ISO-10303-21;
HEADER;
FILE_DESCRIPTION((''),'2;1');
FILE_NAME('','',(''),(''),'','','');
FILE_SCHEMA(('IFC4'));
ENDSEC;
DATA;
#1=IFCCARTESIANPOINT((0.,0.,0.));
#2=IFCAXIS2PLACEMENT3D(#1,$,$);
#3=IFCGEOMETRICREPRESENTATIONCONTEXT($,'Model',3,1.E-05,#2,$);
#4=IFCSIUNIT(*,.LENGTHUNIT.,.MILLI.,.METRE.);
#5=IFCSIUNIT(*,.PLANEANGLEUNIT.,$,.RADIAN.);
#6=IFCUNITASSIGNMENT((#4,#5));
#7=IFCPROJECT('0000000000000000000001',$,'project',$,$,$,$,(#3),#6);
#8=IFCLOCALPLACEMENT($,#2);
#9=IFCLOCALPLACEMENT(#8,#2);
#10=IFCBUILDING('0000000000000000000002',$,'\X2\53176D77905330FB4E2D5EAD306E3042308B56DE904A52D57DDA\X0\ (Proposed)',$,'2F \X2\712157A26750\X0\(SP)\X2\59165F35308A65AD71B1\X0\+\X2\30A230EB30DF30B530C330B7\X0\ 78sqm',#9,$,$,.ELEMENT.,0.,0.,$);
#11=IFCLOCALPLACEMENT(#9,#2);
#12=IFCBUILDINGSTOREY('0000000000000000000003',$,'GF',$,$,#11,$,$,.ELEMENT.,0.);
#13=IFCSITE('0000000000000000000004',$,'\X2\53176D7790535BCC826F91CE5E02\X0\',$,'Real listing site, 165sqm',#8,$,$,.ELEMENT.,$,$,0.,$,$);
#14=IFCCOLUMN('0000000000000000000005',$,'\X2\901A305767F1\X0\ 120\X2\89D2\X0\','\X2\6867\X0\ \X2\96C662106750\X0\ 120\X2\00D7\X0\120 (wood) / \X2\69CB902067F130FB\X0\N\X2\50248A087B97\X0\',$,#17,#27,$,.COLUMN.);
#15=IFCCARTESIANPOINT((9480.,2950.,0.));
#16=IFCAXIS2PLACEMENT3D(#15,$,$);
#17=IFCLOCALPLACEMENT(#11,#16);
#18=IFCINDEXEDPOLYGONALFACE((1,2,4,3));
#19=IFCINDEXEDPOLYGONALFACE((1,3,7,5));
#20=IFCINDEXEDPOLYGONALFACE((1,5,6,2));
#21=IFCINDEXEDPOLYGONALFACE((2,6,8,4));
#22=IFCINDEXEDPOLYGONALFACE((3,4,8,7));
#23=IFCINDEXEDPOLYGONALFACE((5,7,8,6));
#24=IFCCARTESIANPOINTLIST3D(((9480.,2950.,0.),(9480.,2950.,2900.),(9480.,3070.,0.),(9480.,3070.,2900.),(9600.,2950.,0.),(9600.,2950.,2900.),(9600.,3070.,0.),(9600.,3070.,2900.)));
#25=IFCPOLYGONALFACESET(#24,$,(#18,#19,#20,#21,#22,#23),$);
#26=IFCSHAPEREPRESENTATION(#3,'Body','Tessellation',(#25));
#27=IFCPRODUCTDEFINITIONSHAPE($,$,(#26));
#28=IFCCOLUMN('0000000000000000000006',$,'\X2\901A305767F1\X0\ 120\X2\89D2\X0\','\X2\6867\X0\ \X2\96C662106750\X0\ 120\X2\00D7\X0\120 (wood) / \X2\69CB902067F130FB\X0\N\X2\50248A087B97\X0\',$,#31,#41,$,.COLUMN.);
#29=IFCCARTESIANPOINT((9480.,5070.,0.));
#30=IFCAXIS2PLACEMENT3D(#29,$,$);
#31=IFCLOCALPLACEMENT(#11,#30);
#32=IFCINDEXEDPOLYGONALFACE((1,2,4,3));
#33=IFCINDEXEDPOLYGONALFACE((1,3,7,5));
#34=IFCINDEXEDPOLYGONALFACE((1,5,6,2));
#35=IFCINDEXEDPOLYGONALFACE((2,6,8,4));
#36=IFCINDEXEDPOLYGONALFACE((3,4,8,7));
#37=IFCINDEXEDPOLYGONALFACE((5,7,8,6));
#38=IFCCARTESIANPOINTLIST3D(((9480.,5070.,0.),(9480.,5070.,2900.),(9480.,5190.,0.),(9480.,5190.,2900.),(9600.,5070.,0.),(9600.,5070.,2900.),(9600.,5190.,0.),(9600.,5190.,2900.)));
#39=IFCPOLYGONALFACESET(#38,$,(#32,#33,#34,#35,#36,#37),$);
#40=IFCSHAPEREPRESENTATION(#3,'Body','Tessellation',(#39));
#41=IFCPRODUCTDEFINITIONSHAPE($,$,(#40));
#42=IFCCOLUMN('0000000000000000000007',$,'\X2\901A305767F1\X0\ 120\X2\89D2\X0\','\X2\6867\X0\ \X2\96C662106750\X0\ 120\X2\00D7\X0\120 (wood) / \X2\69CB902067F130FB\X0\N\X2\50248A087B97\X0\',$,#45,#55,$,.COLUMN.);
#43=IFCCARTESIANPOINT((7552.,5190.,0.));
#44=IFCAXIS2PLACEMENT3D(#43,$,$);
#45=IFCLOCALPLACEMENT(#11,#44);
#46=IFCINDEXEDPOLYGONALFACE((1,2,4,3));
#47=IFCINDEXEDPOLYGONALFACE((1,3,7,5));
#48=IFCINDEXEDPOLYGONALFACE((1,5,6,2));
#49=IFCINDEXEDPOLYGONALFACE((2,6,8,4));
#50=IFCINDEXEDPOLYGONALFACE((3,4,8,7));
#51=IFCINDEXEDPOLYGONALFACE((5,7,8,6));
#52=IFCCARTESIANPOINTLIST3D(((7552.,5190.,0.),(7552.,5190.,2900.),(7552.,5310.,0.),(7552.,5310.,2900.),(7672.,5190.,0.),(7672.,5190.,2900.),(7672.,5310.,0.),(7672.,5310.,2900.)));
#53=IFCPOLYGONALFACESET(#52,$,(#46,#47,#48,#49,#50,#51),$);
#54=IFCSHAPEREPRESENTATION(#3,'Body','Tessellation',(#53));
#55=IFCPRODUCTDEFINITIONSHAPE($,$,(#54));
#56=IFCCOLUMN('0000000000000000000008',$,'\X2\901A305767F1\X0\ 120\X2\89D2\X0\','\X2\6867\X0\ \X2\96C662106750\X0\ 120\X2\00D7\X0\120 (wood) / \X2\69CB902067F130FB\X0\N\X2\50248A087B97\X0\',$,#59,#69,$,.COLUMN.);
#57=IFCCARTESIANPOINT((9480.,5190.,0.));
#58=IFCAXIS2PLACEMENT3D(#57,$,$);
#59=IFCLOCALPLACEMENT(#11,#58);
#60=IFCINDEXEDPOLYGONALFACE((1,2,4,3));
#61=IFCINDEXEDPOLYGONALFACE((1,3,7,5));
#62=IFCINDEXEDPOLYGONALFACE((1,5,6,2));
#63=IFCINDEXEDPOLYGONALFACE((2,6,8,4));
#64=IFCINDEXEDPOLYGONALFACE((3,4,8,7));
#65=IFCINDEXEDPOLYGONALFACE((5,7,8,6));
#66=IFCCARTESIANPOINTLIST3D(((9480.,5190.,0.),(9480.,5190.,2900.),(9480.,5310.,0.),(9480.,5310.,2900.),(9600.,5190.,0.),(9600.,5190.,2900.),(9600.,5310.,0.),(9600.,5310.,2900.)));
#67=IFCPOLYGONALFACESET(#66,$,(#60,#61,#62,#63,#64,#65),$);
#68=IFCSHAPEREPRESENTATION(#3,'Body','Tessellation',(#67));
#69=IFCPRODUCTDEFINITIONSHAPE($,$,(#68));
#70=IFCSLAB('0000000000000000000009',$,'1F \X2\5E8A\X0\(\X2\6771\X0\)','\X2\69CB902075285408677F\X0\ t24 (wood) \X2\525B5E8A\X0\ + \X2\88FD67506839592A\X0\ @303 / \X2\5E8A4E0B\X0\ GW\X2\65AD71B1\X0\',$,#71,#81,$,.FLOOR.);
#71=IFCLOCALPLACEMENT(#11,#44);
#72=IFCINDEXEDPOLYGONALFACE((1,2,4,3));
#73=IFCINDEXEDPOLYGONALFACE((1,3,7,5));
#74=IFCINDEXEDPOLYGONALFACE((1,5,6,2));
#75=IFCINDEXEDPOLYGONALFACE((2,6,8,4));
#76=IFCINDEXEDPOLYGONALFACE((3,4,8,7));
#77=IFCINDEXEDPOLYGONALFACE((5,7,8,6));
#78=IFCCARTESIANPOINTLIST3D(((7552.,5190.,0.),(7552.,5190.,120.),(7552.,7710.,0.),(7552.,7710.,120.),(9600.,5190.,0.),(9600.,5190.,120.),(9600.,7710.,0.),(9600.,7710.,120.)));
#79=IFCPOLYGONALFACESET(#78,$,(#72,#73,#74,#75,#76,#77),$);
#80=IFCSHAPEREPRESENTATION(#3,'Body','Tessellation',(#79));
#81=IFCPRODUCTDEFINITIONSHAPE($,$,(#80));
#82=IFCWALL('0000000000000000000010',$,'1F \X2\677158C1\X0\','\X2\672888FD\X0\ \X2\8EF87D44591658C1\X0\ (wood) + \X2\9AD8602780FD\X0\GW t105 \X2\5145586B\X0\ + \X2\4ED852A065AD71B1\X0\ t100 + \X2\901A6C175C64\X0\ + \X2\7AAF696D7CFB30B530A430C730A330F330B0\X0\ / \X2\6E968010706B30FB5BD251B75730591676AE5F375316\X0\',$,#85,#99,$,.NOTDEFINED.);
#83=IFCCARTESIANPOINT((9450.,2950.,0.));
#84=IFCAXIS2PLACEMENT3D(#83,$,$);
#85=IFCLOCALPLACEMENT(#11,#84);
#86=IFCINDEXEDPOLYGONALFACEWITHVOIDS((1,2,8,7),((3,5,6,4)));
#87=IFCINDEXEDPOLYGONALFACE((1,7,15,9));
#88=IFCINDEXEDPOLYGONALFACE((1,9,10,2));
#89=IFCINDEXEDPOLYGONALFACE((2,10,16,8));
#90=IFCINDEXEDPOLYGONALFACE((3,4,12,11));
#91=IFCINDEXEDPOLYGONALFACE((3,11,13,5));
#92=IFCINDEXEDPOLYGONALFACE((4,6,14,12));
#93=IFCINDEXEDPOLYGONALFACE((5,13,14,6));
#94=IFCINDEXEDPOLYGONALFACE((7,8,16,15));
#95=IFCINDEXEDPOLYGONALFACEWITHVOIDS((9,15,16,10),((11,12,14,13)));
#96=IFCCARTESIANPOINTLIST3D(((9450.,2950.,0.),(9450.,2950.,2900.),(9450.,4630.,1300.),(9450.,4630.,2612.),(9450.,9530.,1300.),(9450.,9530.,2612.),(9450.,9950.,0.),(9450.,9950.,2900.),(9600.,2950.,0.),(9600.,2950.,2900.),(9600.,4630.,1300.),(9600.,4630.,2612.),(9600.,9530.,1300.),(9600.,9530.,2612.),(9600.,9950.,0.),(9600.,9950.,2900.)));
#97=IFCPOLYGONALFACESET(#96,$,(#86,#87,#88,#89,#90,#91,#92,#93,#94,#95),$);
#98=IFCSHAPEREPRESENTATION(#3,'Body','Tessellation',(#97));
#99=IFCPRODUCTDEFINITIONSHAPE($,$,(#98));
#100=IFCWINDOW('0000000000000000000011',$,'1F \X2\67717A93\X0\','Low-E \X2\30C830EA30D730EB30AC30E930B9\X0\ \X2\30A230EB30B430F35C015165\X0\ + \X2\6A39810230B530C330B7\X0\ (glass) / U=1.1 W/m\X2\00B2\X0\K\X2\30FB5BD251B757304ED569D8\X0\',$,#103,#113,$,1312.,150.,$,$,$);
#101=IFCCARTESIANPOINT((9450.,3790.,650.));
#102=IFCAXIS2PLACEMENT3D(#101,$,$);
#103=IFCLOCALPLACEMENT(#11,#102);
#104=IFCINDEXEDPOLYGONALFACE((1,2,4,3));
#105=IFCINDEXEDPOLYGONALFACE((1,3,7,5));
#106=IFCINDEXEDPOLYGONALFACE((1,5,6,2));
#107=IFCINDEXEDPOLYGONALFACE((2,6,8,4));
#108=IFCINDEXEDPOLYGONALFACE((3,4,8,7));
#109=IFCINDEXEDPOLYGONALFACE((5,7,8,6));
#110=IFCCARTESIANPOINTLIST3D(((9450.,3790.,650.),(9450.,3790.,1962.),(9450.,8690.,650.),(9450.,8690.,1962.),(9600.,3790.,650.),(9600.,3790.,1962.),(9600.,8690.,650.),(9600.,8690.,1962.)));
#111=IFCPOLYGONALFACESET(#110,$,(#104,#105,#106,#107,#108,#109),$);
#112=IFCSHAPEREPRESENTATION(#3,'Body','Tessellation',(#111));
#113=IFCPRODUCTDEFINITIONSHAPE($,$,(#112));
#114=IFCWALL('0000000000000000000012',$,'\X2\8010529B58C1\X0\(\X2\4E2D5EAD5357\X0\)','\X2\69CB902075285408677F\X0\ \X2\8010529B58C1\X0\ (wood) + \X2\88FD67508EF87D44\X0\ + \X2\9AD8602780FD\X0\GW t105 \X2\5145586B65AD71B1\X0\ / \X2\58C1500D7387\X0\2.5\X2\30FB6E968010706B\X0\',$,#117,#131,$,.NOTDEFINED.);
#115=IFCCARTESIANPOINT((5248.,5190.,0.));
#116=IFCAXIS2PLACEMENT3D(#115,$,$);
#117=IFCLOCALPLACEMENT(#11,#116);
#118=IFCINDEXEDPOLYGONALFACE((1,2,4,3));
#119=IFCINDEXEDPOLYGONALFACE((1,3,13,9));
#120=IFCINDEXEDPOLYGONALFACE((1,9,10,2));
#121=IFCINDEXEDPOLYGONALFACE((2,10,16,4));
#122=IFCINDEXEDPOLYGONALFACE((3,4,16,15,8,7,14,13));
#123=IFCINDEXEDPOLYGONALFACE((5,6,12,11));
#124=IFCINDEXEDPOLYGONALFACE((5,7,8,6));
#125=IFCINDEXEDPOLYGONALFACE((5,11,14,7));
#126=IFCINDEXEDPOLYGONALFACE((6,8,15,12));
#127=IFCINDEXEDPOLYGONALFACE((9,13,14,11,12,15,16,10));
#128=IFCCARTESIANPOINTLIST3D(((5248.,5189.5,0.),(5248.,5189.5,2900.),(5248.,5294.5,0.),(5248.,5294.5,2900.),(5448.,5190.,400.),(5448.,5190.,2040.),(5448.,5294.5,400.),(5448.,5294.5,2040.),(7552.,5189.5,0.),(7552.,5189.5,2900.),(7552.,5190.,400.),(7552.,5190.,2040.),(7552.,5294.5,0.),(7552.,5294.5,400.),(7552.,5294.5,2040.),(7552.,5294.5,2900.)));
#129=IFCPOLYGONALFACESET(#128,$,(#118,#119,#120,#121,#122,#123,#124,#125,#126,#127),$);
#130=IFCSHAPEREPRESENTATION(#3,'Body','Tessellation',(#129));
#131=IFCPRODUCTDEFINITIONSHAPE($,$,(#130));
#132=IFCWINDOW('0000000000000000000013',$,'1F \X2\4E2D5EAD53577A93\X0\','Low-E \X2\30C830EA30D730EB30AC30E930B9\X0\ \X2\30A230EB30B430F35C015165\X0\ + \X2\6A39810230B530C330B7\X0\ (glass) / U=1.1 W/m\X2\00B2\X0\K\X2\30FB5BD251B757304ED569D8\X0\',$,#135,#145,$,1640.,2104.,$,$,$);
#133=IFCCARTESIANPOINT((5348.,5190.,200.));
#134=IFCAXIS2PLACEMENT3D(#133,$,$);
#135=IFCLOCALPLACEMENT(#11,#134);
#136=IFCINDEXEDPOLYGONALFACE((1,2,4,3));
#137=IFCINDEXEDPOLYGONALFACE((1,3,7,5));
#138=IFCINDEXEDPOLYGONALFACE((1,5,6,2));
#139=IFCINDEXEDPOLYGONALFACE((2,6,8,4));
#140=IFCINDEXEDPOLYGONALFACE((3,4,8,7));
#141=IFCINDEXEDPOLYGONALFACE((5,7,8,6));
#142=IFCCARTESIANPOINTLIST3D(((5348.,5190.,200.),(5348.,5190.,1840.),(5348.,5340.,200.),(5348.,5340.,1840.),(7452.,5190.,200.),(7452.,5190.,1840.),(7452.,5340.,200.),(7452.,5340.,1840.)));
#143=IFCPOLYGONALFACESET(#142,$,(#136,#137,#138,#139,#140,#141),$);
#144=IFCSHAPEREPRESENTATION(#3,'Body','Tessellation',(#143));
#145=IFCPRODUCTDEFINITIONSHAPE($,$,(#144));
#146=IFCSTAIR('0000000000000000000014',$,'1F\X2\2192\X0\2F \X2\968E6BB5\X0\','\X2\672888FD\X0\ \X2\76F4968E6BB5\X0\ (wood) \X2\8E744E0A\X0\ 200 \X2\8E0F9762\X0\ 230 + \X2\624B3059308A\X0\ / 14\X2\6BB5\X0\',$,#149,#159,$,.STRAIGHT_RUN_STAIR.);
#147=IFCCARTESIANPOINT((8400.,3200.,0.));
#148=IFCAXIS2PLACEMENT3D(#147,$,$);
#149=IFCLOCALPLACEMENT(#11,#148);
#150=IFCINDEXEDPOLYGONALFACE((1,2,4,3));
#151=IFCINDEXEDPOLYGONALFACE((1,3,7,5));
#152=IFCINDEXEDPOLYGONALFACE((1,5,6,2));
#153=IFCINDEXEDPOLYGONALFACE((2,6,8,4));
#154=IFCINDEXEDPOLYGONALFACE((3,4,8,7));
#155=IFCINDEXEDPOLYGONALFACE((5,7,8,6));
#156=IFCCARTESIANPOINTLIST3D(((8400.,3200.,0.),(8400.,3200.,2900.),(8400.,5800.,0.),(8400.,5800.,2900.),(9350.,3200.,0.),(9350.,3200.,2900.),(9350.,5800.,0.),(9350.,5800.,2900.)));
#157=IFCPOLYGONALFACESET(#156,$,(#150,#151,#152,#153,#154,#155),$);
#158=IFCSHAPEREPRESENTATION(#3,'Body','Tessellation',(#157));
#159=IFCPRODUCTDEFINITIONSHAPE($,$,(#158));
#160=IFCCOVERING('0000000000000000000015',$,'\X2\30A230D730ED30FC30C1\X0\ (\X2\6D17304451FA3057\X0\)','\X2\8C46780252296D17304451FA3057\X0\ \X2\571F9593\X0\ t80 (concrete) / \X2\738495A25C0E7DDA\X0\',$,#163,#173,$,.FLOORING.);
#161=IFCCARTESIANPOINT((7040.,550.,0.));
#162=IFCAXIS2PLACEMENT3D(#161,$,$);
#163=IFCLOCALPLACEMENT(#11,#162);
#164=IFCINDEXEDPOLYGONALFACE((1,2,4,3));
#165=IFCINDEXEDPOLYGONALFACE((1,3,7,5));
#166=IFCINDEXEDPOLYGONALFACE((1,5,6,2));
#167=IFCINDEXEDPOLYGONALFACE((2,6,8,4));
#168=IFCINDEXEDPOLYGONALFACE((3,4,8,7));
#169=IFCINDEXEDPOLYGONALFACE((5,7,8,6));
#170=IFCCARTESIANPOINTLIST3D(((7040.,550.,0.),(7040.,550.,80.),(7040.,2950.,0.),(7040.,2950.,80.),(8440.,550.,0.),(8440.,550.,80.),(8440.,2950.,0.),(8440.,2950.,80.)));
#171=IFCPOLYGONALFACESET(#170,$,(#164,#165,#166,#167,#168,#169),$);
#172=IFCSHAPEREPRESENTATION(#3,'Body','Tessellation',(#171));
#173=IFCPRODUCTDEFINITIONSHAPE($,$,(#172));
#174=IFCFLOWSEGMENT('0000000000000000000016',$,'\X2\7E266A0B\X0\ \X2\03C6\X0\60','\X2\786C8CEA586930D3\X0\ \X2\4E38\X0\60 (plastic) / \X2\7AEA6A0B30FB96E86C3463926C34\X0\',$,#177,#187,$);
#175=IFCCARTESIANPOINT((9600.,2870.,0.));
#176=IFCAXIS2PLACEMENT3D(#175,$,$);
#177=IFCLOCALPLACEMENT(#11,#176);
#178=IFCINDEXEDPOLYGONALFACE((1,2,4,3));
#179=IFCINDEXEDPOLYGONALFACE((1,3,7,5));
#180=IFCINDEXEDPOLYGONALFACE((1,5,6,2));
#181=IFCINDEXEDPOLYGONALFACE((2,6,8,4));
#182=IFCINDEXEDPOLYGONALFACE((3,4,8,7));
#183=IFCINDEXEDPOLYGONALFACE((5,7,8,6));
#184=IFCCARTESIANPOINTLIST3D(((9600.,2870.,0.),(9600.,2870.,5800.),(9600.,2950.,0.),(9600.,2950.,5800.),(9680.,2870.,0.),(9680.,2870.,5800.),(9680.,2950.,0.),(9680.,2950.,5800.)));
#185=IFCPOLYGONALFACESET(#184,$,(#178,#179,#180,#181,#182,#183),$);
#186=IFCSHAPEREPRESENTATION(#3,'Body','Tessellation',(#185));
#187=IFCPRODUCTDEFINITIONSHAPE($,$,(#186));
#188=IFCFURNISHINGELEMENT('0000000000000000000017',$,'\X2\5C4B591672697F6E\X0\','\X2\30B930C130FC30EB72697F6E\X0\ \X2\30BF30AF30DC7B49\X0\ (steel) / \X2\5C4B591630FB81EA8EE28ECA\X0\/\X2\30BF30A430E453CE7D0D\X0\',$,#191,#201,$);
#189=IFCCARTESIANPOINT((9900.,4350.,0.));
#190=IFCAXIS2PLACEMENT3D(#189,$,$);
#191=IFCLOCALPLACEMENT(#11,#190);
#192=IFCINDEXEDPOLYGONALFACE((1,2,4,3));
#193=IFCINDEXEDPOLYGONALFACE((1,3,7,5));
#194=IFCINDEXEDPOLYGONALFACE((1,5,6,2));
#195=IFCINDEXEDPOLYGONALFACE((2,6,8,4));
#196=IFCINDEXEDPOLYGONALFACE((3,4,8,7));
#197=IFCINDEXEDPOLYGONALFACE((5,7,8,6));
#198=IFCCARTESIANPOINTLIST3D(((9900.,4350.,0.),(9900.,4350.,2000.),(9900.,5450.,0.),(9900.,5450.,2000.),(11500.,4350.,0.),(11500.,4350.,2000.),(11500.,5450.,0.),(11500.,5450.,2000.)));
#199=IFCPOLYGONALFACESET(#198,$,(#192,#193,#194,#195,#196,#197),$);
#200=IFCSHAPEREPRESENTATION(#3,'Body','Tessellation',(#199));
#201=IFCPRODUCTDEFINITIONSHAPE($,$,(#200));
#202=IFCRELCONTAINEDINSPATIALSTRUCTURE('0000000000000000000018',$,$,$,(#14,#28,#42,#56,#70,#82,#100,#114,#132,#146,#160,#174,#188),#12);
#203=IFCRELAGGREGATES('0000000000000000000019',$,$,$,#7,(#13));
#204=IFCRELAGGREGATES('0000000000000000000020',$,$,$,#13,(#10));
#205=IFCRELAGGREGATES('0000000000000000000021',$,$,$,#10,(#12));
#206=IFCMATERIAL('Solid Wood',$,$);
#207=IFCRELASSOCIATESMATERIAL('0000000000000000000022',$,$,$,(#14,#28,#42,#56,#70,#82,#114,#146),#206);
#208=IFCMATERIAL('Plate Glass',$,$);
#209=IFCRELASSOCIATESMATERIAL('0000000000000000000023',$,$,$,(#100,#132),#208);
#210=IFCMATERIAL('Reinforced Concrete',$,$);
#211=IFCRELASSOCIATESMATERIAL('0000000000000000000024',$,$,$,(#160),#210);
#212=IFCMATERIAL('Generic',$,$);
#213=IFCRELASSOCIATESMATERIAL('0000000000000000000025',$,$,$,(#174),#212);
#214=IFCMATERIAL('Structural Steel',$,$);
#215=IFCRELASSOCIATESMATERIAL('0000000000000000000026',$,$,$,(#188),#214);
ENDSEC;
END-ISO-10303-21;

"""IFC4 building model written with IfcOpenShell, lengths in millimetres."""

from ifc_helpers import new_model, si_unit, frame, frame_2d, origin, place, context, project, spatial, rectangle, extrude, material, element, fill, save


model = new_model("IFC4")

# Units and contexts
model_context = context("Model", 3, precision=1e-05, world=origin())
ifc_project = project(units=[si_unit("LENGTHUNIT", "METRE", prefix="MILLI"), si_unit("PLANEANGLEUNIT", "RADIAN")], contexts=[model_context])

# Site, building, storey
site_placement = place(None, origin())
site = spatial("IfcSite", under=ifc_project, at=site_placement, Name="北海道富良野市", ObjectType="Real listing site, 165sqm", CompositionType="ELEMENT", RefElevation=0.0)
building_placement = place(site_placement, origin())
building = spatial("IfcBuilding", under=site, at=building_placement, Name="北海道・中庭のある回遊動線 (Proposed)", ObjectType="2F 無垢材(SP)外張り断熱+アルミサッシ 78sqm", CompositionType="ELEMENT", ElevationOfRefHeight=0.0, ElevationOfTerrain=0.0)
storey_placement = place(building_placement, origin())
storey = spatial("IfcBuildingStorey", under=building, at=storey_placement, Name="GF", CompositionType="ELEMENT", Elevation=0.0)

# Columns
ifc_material_1 = material(Name="Solid Wood")
column_1_placement = place(storey_placement, frame((9480.0, 2950.0, 0.0)))
element("IfcColumn", 1, at=column_1_placement, inside=storey, material=ifc_material_1, Name="通し柱 120角", Description="桧 集成材 120×120 (wood) / 構造柱・N値計算", PredefinedType="COLUMN", context=model_context, shape_type="SweptSolid", body=[
    extrude(rectangle(XDim=120.0, YDim=120.0, at=frame_2d((60.0, 60.0))), frame((9480.0, 2950.0, 0.0)), (0.0, 0.0, 1.0), 2900.0),
])
column_2_placement = place(storey_placement, frame((9480.0, 5070.0, 0.0)))
element("IfcColumn", 2, at=column_2_placement, inside=storey, material=ifc_material_1, Name="通し柱 120角", Description="桧 集成材 120×120 (wood) / 構造柱・N値計算", PredefinedType="COLUMN", context=model_context, shape_type="SweptSolid", body=[
    extrude(rectangle(XDim=120.0, YDim=120.0, at=frame_2d((60.0, 60.0))), frame((9480.0, 5070.0, 0.0)), (0.0, 0.0, 1.0), 2900.0),
])
column_3_placement = place(storey_placement, frame((7552.0, 5190.0, 0.0)))
element("IfcColumn", 3, at=column_3_placement, inside=storey, material=ifc_material_1, Name="通し柱 120角", Description="桧 集成材 120×120 (wood) / 構造柱・N値計算", PredefinedType="COLUMN", context=model_context, shape_type="SweptSolid", body=[
    extrude(rectangle(XDim=120.0, YDim=120.0, at=frame_2d((60.0, 60.0))), frame((7552.0, 5190.0, 0.0)), (0.0, 0.0, 1.0), 2900.0),
])
column_4_placement = place(storey_placement, frame((9480.0, 5190.0, 0.0)))
element("IfcColumn", 4, at=column_4_placement, inside=storey, material=ifc_material_1, Name="通し柱 120角", Description="桧 集成材 120×120 (wood) / 構造柱・N値計算", PredefinedType="COLUMN", context=model_context, shape_type="SweptSolid", body=[
    extrude(rectangle(XDim=120.0, YDim=120.0, at=frame_2d((60.0, 60.0))), frame((9480.0, 5190.0, 0.0)), (0.0, 0.0, 1.0), 2900.0),
])

# Slab
slab_placement = place(storey_placement, frame((7552.0, 5190.0, 0.0)))
element("IfcSlab", 5, at=slab_placement, inside=storey, material=ifc_material_1, Name="1F 床(東)", Description="構造用合板 t24 (wood) 剛床 + 製材根太 @303 / 床下 GW断熱", PredefinedType="FLOOR", context=model_context, shape_type="SweptSolid", body=[
    extrude(rectangle(XDim=2048.0, YDim=2520.0, at=frame_2d((1024.0, 1260.0))), frame((7552.0, 5190.0, 0.0)), (0.0, 0.0, 1.0), 120.0),
])

# Walls, openings, windows
wall_1_placement = place(storey_placement, frame((9450.0, 2950.0, 0.0)))
wall_1 = element("IfcWall", 6, at=wall_1_placement, inside=storey, material=ifc_material_1, Name="1F 東壁", Description="木製 軸組外壁 (wood) + 高性能GW t105 充填 + 付加断熱 t100 + 通気層 + 窯業系サイディング / 準耐火・寒冷地外皮強化", PredefinedType="NOTDEFINED", context=model_context, shape_type="SweptSolid", body=[
    extrude(rectangle(XDim=150.0, YDim=7000.0, at=frame_2d((75.0, 3500.0))), frame((9450.0, 2950.0, 0.0)), (0.0, 0.0, 1.0), 2900.0),
])
opening_1_placement = place(storey_placement, frame((9450.0, 3790.0, 650.0)))
opening_1 = element("IfcOpeningElement", 7, at=opening_1_placement, cuts=wall_1, PredefinedType="NOTDEFINED", context=model_context, shape_type="SweptSolid", body=[
    extrude(rectangle(XDim=150.0, YDim=4900.0, at=frame_2d((75.0, 2450.0))), frame((9450.0, 3790.0, 650.0)), (0.0, 0.0, 1.0), 1312.0),
])
ifc_material_2 = material(Name="Plate Glass")
window_1_placement = place(storey_placement, frame((9450.0, 3790.0, 650.0)))
window_1 = element("IfcWindow", 8, at=window_1_placement, inside=storey, material=ifc_material_2, Name="1F 東窓", Description="Low-E トリプルガラス アルゴン封入 + 樹脂サッシ (glass) / U=1.1 W/m²K・寒冷地仕様", OverallHeight=1312.0, OverallWidth=150.0, context=model_context, shape_type="SweptSolid", body=[
    extrude(rectangle(XDim=150.0, YDim=4900.0, at=frame_2d((75.0, 2450.0))), frame((9450.0, 3790.0, 650.0)), (0.0, 0.0, 1.0), 1312.0),
])
fill(opening_1, window_1)
wall_2_placement = place(storey_placement, frame((5248.0, 5190.0, 0.0)))
wall_2 = element("IfcWall", 9, at=wall_2_placement, inside=storey, material=ifc_material_1, Name="耐力壁(中庭南)", Description="構造用合板 耐力壁 (wood) + 製材軸組 + 高性能GW t105 充填断熱 / 壁倍率2.5・準耐火", PredefinedType="NOTDEFINED", context=model_context, shape_type="SweptSolid", body=[
    extrude(rectangle(XDim=2304.0, YDim=105.0, at=frame_2d((1152.0, 52.0))), frame((5248.0, 5190.0, 0.0)), (0.0, 0.0, 1.0), 2900.0),
])
opening_2_placement = place(storey_placement, frame((5348.0, 5190.0, 200.0)))
opening_2 = element("IfcOpeningElement", 10, at=opening_2_placement, cuts=wall_2, PredefinedType="NOTDEFINED", context=model_context, shape_type="SweptSolid", body=[
    extrude(rectangle(XDim=2104.0, YDim=150.0, at=frame_2d((1052.0, 75.0))), frame((5348.0, 5190.0, 200.0)), (0.0, 0.0, 1.0), 1640.0),
])
window_2_placement = place(storey_placement, frame((5348.0, 5190.0, 200.0)))
window_2 = element("IfcWindow", 11, at=window_2_placement, inside=storey, material=ifc_material_2, Name="1F 中庭南窓", Description="Low-E トリプルガラス アルゴン封入 + 樹脂サッシ (glass) / U=1.1 W/m²K・寒冷地仕様", OverallHeight=1640.0, OverallWidth=2104.0, context=model_context, shape_type="SweptSolid", body=[
    extrude(rectangle(XDim=2104.0, YDim=150.0, at=frame_2d((1052.0, 75.0))), frame((5348.0, 5190.0, 200.0)), (0.0, 0.0, 1.0), 1640.0),
])
fill(opening_2, window_2)

# Stair
stair_placement = place(storey_placement, frame((8400.0, 3200.0, 0.0)))
element("IfcStair", 12, at=stair_placement, inside=storey, material=ifc_material_1, Name="1F→2F 階段", Description="木製 直階段 (wood) 蹴上 200 踏面 230 + 手すり / 14段", PredefinedType="STRAIGHT_RUN_STAIR", context=model_context, shape_type="SweptSolid", body=[
    extrude(rectangle(XDim=950.0, YDim=2600.0, at=frame_2d((475.0, 1300.0))), frame((8400.0, 3200.0, 0.0)), (0.0, 0.0, 1.0), 2900.0),
])

# Covering
ifc_material_3 = material(Name="Reinforced Concrete")
covering_placement = place(storey_placement, frame((7040.0, 550.0, 0.0)))
element("IfcCovering", 13, at=covering_placement, inside=storey, material=ifc_material_3, Name="アプローチ (洗い出し)", Description="豆砂利洗い出し 土間 t80 (concrete) / 玄関導線", PredefinedType="FLOORING", context=model_context, shape_type="SweptSolid", body=[
    extrude(rectangle(XDim=1400.0, YDim=2400.0, at=frame_2d((700.0, 1200.0))), frame((7040.0, 550.0, 0.0)), (0.0, 0.0, 1.0), 80.0),
])

# Flow segment
ifc_material_4 = material(Name="Generic")
flow_segment_placement = place(storey_placement, frame((9600.0, 2870.0, 0.0)))
element("IfcFlowSegment", 14, at=flow_segment_placement, inside=storey, material=ifc_material_4, Name="縦樋 φ60", Description="硬質塩ビ 丸60 (plastic) / 竪樋・雨水排水", context=model_context, shape_type="SweptSolid", body=[
    extrude(rectangle(XDim=80.0, YDim=80.0, at=frame_2d((40.0, 40.0))), frame((9600.0, 2870.0, 0.0)), (0.0, 0.0, 1.0), 5800.0),
])

# Furnishing element
ifc_material_5 = material(Name="Structural Steel")
furnishing_placement = place(storey_placement, frame((9900.0, 4350.0, 0.0)))
element("IfcFurnishingElement", 15, at=furnishing_placement, inside=storey, material=ifc_material_5, Name="屋外物置", Description="スチール物置 タクボ等 (steel) / 屋外・自転車/タイヤ収納", context=model_context, shape_type="SweptSolid", body=[
    extrude(rectangle(XDim=1600.0, YDim=1100.0, at=frame_2d((800.0, 550.0))), frame((9900.0, 4350.0, 0.0)), (0.0, 0.0, 1.0), 2000.0),
])

save(model, "model.ifc")
